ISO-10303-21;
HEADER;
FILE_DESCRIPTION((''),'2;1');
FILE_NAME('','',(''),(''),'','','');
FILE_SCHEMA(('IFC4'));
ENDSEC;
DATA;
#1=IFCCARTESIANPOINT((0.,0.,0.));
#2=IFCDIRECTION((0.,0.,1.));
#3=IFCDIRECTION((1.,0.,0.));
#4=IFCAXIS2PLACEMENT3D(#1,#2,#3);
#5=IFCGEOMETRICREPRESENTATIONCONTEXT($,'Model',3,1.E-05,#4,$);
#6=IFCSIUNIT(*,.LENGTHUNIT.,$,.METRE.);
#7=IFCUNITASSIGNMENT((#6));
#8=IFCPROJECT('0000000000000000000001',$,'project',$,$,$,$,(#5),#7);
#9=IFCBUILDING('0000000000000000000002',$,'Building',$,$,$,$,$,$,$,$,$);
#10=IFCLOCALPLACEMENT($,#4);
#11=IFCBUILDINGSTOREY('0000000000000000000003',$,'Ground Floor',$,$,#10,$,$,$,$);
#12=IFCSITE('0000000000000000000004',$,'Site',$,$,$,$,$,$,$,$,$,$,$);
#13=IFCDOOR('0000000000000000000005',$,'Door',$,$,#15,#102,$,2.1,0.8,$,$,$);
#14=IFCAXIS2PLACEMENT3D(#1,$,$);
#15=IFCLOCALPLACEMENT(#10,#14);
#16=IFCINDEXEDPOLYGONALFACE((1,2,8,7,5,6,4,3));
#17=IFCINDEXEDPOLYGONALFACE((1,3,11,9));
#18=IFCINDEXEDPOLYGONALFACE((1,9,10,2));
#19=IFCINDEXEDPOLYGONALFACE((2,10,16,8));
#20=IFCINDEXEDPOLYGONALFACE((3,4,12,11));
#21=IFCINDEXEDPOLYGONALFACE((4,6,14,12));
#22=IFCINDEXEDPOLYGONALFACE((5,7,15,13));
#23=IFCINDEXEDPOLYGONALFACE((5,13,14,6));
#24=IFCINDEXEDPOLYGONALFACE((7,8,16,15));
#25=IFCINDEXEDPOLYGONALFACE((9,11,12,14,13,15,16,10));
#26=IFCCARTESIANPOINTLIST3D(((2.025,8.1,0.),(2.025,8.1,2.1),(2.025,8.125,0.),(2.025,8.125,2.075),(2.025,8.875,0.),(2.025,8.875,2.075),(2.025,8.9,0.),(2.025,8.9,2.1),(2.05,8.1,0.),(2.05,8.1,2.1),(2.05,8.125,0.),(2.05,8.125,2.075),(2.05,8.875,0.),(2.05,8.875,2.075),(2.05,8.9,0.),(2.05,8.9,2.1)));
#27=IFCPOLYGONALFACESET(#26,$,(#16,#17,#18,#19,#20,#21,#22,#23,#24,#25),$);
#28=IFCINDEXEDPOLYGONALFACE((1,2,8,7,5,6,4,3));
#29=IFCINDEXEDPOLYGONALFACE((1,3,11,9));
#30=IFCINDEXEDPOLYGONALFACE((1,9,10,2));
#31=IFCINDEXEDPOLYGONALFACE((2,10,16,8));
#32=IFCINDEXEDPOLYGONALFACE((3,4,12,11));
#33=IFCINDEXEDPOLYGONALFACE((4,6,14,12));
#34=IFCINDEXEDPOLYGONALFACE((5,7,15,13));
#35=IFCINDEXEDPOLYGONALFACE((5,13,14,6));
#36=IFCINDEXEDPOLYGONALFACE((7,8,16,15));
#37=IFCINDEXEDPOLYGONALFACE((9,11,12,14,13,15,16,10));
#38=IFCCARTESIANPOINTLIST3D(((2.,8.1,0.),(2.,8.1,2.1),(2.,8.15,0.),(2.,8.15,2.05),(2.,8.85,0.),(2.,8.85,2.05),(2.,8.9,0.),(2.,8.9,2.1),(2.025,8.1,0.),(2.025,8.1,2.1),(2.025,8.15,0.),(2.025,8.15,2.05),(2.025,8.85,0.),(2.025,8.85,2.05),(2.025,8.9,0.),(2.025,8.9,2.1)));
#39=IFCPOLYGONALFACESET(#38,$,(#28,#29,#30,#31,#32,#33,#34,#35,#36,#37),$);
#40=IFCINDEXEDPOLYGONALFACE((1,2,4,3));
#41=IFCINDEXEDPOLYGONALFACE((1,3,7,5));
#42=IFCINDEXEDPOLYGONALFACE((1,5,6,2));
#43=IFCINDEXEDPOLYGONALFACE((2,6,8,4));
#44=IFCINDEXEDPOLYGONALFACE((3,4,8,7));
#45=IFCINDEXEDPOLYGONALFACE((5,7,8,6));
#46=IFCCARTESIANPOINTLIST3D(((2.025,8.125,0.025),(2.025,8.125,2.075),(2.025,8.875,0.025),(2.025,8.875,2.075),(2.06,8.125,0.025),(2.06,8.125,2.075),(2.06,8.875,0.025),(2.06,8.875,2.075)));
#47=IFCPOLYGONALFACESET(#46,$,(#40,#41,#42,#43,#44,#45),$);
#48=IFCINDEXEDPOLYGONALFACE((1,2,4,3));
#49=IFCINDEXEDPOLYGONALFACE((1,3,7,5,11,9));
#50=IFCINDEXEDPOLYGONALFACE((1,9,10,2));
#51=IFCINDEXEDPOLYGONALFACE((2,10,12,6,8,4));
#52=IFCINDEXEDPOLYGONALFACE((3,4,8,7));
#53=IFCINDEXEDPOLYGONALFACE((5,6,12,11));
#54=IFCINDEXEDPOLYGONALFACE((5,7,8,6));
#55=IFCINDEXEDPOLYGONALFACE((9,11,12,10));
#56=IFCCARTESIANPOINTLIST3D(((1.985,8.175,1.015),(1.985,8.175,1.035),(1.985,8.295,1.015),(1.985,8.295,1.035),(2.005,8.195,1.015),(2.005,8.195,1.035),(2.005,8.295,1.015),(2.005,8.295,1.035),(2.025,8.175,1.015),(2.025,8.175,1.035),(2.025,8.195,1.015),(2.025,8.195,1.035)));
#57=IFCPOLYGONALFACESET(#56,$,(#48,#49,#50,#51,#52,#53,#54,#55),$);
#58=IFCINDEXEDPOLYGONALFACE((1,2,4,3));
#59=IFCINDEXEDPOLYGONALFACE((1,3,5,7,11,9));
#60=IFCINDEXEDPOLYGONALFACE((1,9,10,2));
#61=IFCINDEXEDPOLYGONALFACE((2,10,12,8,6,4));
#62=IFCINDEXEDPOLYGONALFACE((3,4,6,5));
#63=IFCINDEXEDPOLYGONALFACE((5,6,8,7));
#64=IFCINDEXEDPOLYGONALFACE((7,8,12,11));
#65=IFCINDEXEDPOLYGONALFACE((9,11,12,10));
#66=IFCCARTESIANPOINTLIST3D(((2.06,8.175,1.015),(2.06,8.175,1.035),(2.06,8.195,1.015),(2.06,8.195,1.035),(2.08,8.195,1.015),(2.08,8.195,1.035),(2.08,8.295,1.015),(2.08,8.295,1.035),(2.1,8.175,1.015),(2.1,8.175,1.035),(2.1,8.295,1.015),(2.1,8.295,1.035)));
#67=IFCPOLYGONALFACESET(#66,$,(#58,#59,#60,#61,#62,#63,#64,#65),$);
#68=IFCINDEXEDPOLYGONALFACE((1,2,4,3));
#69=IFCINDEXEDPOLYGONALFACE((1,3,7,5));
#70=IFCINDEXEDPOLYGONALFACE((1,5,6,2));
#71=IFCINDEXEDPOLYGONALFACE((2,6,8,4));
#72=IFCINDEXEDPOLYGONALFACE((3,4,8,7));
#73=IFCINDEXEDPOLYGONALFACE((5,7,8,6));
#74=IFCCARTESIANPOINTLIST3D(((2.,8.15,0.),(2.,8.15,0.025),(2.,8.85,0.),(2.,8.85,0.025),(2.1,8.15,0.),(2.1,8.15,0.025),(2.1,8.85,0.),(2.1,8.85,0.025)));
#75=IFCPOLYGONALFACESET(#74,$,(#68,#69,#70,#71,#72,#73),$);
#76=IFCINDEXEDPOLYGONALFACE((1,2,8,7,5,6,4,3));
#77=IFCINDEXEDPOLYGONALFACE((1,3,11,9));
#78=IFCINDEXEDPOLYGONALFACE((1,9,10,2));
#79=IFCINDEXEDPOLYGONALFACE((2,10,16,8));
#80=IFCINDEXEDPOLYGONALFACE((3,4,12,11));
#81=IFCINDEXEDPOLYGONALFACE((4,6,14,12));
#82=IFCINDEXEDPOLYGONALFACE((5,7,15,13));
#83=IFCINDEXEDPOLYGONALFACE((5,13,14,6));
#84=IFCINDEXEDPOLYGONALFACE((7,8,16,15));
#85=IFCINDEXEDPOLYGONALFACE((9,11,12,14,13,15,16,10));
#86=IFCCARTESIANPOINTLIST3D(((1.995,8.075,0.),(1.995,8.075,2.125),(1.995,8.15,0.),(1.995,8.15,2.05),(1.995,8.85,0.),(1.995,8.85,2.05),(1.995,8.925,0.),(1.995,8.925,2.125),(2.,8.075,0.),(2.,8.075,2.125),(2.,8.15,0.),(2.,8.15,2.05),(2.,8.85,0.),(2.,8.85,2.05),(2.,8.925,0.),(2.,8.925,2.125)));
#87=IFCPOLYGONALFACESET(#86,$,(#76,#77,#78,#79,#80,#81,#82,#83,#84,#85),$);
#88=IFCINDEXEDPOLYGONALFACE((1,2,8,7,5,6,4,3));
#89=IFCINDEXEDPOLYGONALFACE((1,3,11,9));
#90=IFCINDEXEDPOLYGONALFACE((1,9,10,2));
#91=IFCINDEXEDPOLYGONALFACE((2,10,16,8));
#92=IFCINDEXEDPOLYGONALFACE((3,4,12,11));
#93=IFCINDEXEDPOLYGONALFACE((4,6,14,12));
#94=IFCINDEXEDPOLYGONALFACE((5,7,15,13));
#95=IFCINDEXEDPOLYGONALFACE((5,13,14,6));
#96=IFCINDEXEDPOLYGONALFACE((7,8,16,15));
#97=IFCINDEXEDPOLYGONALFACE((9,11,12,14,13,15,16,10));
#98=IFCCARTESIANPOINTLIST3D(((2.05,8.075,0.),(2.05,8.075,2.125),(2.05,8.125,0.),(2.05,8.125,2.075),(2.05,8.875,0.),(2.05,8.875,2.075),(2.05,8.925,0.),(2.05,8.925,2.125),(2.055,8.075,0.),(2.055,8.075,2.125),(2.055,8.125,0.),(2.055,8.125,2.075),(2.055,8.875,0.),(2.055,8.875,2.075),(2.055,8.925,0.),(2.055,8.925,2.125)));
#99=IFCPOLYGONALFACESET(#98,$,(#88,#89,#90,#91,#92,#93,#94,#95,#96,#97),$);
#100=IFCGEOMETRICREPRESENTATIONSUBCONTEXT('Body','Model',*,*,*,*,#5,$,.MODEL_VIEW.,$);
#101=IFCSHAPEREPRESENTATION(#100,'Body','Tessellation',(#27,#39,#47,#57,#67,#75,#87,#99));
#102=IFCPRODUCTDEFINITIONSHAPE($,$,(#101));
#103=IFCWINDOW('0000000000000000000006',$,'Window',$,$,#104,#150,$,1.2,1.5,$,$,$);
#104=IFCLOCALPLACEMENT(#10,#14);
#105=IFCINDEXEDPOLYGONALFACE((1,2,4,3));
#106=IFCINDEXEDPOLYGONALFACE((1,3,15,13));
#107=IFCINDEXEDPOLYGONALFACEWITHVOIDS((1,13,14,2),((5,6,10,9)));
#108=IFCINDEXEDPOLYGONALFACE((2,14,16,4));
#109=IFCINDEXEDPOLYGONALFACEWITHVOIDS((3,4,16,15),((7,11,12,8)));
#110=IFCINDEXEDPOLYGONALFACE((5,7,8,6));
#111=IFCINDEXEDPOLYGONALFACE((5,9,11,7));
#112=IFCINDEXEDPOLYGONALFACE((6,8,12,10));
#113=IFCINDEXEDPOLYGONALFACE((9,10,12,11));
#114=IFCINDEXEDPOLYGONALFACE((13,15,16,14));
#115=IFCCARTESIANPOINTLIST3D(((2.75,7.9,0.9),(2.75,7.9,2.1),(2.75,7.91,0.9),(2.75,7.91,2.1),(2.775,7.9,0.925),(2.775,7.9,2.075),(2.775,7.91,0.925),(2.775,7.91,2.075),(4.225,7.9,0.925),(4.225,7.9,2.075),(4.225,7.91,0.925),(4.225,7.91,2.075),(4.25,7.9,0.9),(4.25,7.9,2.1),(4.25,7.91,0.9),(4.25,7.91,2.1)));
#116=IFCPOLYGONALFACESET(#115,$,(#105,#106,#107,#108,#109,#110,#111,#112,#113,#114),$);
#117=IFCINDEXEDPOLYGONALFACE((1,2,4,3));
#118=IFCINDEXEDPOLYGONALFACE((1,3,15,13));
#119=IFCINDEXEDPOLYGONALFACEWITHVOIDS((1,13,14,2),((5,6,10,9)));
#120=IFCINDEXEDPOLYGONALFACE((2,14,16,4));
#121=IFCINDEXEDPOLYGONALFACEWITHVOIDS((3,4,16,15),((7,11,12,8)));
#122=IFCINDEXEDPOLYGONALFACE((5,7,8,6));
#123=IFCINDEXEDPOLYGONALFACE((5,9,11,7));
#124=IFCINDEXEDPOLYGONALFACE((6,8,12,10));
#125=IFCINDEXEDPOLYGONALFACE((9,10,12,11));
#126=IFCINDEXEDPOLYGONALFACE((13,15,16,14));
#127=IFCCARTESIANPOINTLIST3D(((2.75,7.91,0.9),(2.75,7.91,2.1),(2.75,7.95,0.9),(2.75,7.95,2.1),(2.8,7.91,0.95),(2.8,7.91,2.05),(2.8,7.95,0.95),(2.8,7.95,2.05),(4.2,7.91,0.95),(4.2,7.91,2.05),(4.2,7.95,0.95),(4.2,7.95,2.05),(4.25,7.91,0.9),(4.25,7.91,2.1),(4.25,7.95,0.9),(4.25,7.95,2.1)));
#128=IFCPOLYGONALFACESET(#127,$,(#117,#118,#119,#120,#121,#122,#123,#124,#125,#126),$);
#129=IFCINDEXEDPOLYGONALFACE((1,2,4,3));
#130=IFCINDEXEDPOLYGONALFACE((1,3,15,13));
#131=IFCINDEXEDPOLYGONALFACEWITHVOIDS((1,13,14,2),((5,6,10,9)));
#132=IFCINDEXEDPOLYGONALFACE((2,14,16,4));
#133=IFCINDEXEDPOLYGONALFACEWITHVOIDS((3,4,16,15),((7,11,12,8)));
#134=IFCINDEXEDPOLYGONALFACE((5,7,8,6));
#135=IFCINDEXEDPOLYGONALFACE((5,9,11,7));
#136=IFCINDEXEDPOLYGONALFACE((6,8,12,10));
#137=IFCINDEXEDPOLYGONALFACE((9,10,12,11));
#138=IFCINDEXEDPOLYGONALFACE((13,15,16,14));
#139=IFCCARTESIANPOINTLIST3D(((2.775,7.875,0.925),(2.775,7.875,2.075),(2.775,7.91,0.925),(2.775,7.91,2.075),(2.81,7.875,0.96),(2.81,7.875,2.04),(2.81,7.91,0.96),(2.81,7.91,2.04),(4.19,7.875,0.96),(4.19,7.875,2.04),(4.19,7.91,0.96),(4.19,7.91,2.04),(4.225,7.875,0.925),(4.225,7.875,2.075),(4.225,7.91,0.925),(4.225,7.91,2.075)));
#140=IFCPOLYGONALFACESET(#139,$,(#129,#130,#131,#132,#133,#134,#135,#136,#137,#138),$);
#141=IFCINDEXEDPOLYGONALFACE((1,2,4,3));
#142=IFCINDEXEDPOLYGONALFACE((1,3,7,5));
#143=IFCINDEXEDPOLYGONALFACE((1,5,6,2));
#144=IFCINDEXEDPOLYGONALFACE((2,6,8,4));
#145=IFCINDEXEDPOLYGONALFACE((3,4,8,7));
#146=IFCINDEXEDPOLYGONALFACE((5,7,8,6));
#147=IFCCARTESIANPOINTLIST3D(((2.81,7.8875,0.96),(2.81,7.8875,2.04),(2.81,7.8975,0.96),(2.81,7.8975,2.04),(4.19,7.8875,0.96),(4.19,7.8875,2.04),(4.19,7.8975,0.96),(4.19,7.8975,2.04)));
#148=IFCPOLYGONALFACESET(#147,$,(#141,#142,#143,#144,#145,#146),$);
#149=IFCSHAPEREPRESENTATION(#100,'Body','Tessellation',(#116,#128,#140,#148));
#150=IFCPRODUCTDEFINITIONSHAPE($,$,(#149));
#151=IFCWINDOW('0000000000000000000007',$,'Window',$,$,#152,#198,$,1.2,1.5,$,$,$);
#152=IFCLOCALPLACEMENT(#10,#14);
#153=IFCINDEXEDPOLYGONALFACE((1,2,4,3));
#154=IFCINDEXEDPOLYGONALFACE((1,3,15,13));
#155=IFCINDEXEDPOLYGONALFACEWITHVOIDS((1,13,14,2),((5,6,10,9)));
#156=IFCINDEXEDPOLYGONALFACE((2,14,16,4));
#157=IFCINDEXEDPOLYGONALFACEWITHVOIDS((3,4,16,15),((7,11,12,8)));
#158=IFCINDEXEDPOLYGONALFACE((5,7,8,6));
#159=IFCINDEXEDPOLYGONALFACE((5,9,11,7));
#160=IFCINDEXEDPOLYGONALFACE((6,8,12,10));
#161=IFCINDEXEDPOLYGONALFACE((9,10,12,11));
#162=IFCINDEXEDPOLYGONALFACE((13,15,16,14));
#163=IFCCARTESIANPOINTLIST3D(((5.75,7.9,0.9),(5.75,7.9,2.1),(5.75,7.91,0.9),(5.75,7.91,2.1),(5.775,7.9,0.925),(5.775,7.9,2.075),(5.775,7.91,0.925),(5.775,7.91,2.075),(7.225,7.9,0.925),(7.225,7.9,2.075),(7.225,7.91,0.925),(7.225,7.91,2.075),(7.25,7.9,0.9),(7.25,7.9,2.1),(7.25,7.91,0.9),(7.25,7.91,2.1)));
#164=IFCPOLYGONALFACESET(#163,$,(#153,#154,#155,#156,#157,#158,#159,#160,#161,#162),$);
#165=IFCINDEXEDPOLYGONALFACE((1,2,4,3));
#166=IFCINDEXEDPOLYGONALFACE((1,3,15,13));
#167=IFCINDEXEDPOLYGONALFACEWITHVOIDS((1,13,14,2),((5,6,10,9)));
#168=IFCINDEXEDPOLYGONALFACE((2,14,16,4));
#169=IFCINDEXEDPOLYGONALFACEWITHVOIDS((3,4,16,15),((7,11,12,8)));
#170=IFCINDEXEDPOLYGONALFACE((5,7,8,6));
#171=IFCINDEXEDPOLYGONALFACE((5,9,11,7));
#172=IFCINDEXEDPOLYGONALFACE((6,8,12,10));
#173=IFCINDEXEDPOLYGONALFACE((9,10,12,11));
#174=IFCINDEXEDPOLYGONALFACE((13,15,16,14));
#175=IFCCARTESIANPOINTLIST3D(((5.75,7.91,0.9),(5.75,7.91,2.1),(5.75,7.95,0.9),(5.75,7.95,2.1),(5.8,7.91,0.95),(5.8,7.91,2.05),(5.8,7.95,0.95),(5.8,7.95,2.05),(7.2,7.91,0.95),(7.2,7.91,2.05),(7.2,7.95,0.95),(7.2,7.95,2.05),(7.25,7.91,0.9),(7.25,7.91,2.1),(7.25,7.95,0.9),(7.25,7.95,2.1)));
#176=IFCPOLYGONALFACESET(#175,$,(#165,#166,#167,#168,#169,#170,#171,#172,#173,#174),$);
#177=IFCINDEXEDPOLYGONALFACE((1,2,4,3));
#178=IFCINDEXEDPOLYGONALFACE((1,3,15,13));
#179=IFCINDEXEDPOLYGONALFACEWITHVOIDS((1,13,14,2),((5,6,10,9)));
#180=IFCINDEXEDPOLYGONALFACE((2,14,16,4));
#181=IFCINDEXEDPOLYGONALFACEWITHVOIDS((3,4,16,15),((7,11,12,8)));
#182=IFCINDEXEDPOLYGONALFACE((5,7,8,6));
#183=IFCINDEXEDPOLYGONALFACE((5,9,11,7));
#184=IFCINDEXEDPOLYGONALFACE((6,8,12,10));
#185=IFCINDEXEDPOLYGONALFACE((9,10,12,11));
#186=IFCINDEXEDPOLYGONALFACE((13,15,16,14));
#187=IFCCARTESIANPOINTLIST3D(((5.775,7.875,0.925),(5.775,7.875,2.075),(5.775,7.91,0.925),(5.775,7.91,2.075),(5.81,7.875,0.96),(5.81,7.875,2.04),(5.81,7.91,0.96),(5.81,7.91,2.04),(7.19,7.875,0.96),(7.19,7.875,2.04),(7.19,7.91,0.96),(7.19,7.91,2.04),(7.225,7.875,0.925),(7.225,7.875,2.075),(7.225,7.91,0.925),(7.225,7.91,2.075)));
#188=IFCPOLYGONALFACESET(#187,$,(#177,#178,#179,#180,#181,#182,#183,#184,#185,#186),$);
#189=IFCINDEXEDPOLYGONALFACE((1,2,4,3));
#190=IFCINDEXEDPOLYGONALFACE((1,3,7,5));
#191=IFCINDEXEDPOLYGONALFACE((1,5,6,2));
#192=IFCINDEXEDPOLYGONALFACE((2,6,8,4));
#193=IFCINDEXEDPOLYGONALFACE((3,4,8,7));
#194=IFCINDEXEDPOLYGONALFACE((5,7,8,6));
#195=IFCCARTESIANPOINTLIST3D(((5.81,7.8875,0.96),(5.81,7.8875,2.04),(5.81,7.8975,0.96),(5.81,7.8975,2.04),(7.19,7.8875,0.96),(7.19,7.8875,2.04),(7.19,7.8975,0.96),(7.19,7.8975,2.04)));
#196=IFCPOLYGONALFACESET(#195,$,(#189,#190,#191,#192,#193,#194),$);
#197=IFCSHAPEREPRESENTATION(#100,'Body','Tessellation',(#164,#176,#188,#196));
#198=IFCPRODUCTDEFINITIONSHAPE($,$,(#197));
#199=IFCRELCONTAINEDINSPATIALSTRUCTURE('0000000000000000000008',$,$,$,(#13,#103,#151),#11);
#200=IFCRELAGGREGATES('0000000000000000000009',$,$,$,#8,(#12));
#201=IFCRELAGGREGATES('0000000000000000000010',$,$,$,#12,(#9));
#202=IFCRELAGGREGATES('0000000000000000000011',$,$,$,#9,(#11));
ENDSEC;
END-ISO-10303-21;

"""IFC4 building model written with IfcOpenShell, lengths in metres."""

from ifc_helpers import new_model, si_unit, frame, origin_with_axes, place, context, subcontext, project, spatial, line, indexed_curve, outline, extrude, element, save


model = new_model("IFC4")

# Units and contexts
model_context = context("Model", 3, precision=1e-05, world=origin_with_axes())
body_context = subcontext(model_context, "Body", "Model", "MODEL_VIEW")
ifc_project = project(units=[si_unit("LENGTHUNIT", "METRE")], contexts=[model_context])

# Site, building, storey
site = spatial("IfcSite", under=ifc_project, Name="Site")
building = spatial("IfcBuilding", under=site, Name="Building")
storey_placement = place(None, origin_with_axes())
storey = spatial("IfcBuildingStorey", under=building, at=storey_placement, Name="Ground Floor")

# Door
door_1_placement = place(storey_placement, frame((2.0, 8.9, 0.0), z_axis=(0.0, 0.0, 1.0), x_axis=(0.0, -1.0, 0.0)))
element("IfcDoor", 1, at=door_1_placement, inside=storey, Name="Door", OverallHeight=2.1, OverallWidth=0.8, context=body_context, shape_type="SweptSolid", body=[
    extrude(outline(indexed_curve([(0.0, 0.0), (0.0, 2.1), (0.8, 2.1), (0.8, 0.0), (0.775, 0.0), (0.775, 2.075), (0.025, 2.075), (0.025, 0.0)], segments=[line(1, 2, 3, 4, 5, 6, 7, 8, 1)])), frame((0.0, 0.025, 0.0), z_axis=(0.0, -1.0, 0.0), x_axis=(1.0, 0.0, 0.0)), (0.0, 0.0, -1.0), 0.025),
    extrude(outline(indexed_curve([(0.0, 0.0), (0.0, 2.1), (0.8, 2.1), (0.8, 0.0), (0.75, 0.0), (0.75, 2.05), (0.05, 2.05), (0.05, 0.0)], segments=[line(1, 2, 3, 4, 5, 6, 7, 8, 1)])), frame((0.0, 0.0, 0.0), z_axis=(0.0, -1.0, 0.0), x_axis=(1.0, 0.0, 0.0)), (0.0, 0.0, -1.0), 0.025),
    extrude(outline(indexed_curve([(0.0, 0.0), (0.75, 0.0), (0.75, 0.035), (0.0, 0.035)], segments=[line(1, 2, 3, 4, 1)])), frame((0.025, 0.025, 0.025), z_axis=(0.0, 0.0, 1.0), x_axis=(1.0, 0.0, 0.0)), (0.0, 0.0, 1.0), 2.05),
    extrude(outline(indexed_curve([(0.0, 0.0), (0.0, -0.04), (-0.12, -0.04), (-0.12, -0.02), (-0.02, -0.02), (-0.02, 0.0)], segments=[line(1, 2, 3, 4, 5, 6, 1)])), frame((0.725, 0.025, 1.015), z_axis=(0.0, 0.0, 1.0), x_axis=(1.0, 0.0, 0.0)), (0.0, 0.0, 1.0), 0.02),
    extrude(outline(indexed_curve([(0.0, 0.0), (0.0, 0.04), (-0.12, 0.04), (-0.12, 0.02), (-0.02, 0.02), (-0.02, 0.0)], segments=[line(1, 2, 3, 4, 5, 6, 1)])), frame((0.725, 0.06, 1.015), z_axis=(0.0, 0.0, 1.0), x_axis=(1.0, 0.0, 0.0)), (0.0, 0.0, 1.0), 0.02),
    extrude(outline(indexed_curve([(0.0, 0.0), (0.7, 0.0), (0.7, 0.1), (0.0, 0.1)], segments=[line(1, 2, 3, 4, 1)])), frame((0.05, 0.0, 0.0), z_axis=(0.0, 0.0, 1.0), x_axis=(1.0, 0.0, 0.0)), (0.0, 0.0, 1.0), 0.025),
    extrude(outline(indexed_curve([(0.0, 0.0), (0.0, 2.125), (0.85, 2.125), (0.85, 0.0), (0.775, 0.0), (0.775, 2.05), (0.075, 2.05), (0.075, 0.0)], segments=[line(1, 2, 3, 4, 5, 6, 7, 8, 1)])), frame((-0.025, -0.005, 0.0), z_axis=(0.0, -1.0, 0.0), x_axis=(1.0, 0.0, 0.0)), (0.0, 0.0, -1.0), 0.005),
    extrude(outline(indexed_curve([(0.0, 0.0), (0.0, 2.125), (0.85, 2.125), (0.85, 0.0), (0.8, 0.0), (0.8, 2.075), (0.05, 2.075), (0.05, 0.0)], segments=[line(1, 2, 3, 4, 5, 6, 7, 8, 1)])), frame((-0.025, 0.05, 0.0), z_axis=(0.0, -1.0, 0.0), x_axis=(1.0, 0.0, 0.0)), (0.0, 0.0, -1.0), 0.005),
])

# Windows
for number, where, z_axis, x_axis, name in (
    (2, (4.25, 8.0, 0.9), (0.0, 0.0, 1.0), (-1.0, 0.0, 0.0), "Window"),
    (3, (7.25, 8.0, 0.9), (0.0, 0.0, 1.0), (-1.0, 0.0, 0.0), "Window"),
):
    element("IfcWindow", number, at=place(storey_placement, frame(where, z_axis=z_axis, x_axis=x_axis)), inside=storey, Name=name, OverallHeight=1.2, OverallWidth=1.5, context=body_context, shape_type="SweptSolid", body=[
        extrude(outline(indexed_curve([(0.0, 0.0), (1.5, 0.0), (1.5, 1.2), (0.0, 1.2)], segments=[line(1, 2, 3, 4, 1)]), holes=[indexed_curve([(0.025, 0.025), (1.475, 0.025), (1.475, 1.175), (0.025, 1.175)], segments=[line(1, 2, 3, 4, 1)])]), frame((0.0, 0.09, 0.0), z_axis=(0.0, -1.0, 0.0), x_axis=(1.0, 0.0, 0.0)), (0.0, 0.0, -1.0), 0.01),
        extrude(outline(indexed_curve([(0.0, 0.0), (1.5, 0.0), (1.5, 1.2), (0.0, 1.2)], segments=[line(1, 2, 3, 4, 1)]), holes=[indexed_curve([(0.05, 0.05), (1.45, 0.05), (1.45, 1.15), (0.05, 1.15)], segments=[line(1, 2, 3, 4, 1)])]), frame((0.0, 0.05, 0.0), z_axis=(0.0, -1.0, 0.0), x_axis=(1.0, 0.0, 0.0)), (0.0, 0.0, -1.0), 0.04),
        extrude(outline(indexed_curve([(0.0, 0.0), (1.45, 0.0), (1.45, 1.15), (0.0, 1.15)], segments=[line(1, 2, 3, 4, 1)]), holes=[indexed_curve([(0.035, 0.035), (1.415, 0.035), (1.415, 1.115), (0.035, 1.115)], segments=[line(1, 2, 3, 4, 1)])]), frame((0.025, 0.09, 0.025), z_axis=(0.0, -1.0, 0.0), x_axis=(1.0, 0.0, 0.0)), (0.0, 0.0, -1.0), 0.035),
        extrude(outline(indexed_curve([(0.035, 0.035), (1.415, 0.035), (1.415, 1.115), (0.035, 1.115)], segments=[line(1, 2, 3, 4, 1)])), frame((0.025, 0.1025, 0.025), z_axis=(0.0, -1.0, 0.0), x_axis=(1.0, 0.0, 0.0)), (0.0, 0.0, -1.0), 0.01),
    ])

save(model, "model.ifc")
